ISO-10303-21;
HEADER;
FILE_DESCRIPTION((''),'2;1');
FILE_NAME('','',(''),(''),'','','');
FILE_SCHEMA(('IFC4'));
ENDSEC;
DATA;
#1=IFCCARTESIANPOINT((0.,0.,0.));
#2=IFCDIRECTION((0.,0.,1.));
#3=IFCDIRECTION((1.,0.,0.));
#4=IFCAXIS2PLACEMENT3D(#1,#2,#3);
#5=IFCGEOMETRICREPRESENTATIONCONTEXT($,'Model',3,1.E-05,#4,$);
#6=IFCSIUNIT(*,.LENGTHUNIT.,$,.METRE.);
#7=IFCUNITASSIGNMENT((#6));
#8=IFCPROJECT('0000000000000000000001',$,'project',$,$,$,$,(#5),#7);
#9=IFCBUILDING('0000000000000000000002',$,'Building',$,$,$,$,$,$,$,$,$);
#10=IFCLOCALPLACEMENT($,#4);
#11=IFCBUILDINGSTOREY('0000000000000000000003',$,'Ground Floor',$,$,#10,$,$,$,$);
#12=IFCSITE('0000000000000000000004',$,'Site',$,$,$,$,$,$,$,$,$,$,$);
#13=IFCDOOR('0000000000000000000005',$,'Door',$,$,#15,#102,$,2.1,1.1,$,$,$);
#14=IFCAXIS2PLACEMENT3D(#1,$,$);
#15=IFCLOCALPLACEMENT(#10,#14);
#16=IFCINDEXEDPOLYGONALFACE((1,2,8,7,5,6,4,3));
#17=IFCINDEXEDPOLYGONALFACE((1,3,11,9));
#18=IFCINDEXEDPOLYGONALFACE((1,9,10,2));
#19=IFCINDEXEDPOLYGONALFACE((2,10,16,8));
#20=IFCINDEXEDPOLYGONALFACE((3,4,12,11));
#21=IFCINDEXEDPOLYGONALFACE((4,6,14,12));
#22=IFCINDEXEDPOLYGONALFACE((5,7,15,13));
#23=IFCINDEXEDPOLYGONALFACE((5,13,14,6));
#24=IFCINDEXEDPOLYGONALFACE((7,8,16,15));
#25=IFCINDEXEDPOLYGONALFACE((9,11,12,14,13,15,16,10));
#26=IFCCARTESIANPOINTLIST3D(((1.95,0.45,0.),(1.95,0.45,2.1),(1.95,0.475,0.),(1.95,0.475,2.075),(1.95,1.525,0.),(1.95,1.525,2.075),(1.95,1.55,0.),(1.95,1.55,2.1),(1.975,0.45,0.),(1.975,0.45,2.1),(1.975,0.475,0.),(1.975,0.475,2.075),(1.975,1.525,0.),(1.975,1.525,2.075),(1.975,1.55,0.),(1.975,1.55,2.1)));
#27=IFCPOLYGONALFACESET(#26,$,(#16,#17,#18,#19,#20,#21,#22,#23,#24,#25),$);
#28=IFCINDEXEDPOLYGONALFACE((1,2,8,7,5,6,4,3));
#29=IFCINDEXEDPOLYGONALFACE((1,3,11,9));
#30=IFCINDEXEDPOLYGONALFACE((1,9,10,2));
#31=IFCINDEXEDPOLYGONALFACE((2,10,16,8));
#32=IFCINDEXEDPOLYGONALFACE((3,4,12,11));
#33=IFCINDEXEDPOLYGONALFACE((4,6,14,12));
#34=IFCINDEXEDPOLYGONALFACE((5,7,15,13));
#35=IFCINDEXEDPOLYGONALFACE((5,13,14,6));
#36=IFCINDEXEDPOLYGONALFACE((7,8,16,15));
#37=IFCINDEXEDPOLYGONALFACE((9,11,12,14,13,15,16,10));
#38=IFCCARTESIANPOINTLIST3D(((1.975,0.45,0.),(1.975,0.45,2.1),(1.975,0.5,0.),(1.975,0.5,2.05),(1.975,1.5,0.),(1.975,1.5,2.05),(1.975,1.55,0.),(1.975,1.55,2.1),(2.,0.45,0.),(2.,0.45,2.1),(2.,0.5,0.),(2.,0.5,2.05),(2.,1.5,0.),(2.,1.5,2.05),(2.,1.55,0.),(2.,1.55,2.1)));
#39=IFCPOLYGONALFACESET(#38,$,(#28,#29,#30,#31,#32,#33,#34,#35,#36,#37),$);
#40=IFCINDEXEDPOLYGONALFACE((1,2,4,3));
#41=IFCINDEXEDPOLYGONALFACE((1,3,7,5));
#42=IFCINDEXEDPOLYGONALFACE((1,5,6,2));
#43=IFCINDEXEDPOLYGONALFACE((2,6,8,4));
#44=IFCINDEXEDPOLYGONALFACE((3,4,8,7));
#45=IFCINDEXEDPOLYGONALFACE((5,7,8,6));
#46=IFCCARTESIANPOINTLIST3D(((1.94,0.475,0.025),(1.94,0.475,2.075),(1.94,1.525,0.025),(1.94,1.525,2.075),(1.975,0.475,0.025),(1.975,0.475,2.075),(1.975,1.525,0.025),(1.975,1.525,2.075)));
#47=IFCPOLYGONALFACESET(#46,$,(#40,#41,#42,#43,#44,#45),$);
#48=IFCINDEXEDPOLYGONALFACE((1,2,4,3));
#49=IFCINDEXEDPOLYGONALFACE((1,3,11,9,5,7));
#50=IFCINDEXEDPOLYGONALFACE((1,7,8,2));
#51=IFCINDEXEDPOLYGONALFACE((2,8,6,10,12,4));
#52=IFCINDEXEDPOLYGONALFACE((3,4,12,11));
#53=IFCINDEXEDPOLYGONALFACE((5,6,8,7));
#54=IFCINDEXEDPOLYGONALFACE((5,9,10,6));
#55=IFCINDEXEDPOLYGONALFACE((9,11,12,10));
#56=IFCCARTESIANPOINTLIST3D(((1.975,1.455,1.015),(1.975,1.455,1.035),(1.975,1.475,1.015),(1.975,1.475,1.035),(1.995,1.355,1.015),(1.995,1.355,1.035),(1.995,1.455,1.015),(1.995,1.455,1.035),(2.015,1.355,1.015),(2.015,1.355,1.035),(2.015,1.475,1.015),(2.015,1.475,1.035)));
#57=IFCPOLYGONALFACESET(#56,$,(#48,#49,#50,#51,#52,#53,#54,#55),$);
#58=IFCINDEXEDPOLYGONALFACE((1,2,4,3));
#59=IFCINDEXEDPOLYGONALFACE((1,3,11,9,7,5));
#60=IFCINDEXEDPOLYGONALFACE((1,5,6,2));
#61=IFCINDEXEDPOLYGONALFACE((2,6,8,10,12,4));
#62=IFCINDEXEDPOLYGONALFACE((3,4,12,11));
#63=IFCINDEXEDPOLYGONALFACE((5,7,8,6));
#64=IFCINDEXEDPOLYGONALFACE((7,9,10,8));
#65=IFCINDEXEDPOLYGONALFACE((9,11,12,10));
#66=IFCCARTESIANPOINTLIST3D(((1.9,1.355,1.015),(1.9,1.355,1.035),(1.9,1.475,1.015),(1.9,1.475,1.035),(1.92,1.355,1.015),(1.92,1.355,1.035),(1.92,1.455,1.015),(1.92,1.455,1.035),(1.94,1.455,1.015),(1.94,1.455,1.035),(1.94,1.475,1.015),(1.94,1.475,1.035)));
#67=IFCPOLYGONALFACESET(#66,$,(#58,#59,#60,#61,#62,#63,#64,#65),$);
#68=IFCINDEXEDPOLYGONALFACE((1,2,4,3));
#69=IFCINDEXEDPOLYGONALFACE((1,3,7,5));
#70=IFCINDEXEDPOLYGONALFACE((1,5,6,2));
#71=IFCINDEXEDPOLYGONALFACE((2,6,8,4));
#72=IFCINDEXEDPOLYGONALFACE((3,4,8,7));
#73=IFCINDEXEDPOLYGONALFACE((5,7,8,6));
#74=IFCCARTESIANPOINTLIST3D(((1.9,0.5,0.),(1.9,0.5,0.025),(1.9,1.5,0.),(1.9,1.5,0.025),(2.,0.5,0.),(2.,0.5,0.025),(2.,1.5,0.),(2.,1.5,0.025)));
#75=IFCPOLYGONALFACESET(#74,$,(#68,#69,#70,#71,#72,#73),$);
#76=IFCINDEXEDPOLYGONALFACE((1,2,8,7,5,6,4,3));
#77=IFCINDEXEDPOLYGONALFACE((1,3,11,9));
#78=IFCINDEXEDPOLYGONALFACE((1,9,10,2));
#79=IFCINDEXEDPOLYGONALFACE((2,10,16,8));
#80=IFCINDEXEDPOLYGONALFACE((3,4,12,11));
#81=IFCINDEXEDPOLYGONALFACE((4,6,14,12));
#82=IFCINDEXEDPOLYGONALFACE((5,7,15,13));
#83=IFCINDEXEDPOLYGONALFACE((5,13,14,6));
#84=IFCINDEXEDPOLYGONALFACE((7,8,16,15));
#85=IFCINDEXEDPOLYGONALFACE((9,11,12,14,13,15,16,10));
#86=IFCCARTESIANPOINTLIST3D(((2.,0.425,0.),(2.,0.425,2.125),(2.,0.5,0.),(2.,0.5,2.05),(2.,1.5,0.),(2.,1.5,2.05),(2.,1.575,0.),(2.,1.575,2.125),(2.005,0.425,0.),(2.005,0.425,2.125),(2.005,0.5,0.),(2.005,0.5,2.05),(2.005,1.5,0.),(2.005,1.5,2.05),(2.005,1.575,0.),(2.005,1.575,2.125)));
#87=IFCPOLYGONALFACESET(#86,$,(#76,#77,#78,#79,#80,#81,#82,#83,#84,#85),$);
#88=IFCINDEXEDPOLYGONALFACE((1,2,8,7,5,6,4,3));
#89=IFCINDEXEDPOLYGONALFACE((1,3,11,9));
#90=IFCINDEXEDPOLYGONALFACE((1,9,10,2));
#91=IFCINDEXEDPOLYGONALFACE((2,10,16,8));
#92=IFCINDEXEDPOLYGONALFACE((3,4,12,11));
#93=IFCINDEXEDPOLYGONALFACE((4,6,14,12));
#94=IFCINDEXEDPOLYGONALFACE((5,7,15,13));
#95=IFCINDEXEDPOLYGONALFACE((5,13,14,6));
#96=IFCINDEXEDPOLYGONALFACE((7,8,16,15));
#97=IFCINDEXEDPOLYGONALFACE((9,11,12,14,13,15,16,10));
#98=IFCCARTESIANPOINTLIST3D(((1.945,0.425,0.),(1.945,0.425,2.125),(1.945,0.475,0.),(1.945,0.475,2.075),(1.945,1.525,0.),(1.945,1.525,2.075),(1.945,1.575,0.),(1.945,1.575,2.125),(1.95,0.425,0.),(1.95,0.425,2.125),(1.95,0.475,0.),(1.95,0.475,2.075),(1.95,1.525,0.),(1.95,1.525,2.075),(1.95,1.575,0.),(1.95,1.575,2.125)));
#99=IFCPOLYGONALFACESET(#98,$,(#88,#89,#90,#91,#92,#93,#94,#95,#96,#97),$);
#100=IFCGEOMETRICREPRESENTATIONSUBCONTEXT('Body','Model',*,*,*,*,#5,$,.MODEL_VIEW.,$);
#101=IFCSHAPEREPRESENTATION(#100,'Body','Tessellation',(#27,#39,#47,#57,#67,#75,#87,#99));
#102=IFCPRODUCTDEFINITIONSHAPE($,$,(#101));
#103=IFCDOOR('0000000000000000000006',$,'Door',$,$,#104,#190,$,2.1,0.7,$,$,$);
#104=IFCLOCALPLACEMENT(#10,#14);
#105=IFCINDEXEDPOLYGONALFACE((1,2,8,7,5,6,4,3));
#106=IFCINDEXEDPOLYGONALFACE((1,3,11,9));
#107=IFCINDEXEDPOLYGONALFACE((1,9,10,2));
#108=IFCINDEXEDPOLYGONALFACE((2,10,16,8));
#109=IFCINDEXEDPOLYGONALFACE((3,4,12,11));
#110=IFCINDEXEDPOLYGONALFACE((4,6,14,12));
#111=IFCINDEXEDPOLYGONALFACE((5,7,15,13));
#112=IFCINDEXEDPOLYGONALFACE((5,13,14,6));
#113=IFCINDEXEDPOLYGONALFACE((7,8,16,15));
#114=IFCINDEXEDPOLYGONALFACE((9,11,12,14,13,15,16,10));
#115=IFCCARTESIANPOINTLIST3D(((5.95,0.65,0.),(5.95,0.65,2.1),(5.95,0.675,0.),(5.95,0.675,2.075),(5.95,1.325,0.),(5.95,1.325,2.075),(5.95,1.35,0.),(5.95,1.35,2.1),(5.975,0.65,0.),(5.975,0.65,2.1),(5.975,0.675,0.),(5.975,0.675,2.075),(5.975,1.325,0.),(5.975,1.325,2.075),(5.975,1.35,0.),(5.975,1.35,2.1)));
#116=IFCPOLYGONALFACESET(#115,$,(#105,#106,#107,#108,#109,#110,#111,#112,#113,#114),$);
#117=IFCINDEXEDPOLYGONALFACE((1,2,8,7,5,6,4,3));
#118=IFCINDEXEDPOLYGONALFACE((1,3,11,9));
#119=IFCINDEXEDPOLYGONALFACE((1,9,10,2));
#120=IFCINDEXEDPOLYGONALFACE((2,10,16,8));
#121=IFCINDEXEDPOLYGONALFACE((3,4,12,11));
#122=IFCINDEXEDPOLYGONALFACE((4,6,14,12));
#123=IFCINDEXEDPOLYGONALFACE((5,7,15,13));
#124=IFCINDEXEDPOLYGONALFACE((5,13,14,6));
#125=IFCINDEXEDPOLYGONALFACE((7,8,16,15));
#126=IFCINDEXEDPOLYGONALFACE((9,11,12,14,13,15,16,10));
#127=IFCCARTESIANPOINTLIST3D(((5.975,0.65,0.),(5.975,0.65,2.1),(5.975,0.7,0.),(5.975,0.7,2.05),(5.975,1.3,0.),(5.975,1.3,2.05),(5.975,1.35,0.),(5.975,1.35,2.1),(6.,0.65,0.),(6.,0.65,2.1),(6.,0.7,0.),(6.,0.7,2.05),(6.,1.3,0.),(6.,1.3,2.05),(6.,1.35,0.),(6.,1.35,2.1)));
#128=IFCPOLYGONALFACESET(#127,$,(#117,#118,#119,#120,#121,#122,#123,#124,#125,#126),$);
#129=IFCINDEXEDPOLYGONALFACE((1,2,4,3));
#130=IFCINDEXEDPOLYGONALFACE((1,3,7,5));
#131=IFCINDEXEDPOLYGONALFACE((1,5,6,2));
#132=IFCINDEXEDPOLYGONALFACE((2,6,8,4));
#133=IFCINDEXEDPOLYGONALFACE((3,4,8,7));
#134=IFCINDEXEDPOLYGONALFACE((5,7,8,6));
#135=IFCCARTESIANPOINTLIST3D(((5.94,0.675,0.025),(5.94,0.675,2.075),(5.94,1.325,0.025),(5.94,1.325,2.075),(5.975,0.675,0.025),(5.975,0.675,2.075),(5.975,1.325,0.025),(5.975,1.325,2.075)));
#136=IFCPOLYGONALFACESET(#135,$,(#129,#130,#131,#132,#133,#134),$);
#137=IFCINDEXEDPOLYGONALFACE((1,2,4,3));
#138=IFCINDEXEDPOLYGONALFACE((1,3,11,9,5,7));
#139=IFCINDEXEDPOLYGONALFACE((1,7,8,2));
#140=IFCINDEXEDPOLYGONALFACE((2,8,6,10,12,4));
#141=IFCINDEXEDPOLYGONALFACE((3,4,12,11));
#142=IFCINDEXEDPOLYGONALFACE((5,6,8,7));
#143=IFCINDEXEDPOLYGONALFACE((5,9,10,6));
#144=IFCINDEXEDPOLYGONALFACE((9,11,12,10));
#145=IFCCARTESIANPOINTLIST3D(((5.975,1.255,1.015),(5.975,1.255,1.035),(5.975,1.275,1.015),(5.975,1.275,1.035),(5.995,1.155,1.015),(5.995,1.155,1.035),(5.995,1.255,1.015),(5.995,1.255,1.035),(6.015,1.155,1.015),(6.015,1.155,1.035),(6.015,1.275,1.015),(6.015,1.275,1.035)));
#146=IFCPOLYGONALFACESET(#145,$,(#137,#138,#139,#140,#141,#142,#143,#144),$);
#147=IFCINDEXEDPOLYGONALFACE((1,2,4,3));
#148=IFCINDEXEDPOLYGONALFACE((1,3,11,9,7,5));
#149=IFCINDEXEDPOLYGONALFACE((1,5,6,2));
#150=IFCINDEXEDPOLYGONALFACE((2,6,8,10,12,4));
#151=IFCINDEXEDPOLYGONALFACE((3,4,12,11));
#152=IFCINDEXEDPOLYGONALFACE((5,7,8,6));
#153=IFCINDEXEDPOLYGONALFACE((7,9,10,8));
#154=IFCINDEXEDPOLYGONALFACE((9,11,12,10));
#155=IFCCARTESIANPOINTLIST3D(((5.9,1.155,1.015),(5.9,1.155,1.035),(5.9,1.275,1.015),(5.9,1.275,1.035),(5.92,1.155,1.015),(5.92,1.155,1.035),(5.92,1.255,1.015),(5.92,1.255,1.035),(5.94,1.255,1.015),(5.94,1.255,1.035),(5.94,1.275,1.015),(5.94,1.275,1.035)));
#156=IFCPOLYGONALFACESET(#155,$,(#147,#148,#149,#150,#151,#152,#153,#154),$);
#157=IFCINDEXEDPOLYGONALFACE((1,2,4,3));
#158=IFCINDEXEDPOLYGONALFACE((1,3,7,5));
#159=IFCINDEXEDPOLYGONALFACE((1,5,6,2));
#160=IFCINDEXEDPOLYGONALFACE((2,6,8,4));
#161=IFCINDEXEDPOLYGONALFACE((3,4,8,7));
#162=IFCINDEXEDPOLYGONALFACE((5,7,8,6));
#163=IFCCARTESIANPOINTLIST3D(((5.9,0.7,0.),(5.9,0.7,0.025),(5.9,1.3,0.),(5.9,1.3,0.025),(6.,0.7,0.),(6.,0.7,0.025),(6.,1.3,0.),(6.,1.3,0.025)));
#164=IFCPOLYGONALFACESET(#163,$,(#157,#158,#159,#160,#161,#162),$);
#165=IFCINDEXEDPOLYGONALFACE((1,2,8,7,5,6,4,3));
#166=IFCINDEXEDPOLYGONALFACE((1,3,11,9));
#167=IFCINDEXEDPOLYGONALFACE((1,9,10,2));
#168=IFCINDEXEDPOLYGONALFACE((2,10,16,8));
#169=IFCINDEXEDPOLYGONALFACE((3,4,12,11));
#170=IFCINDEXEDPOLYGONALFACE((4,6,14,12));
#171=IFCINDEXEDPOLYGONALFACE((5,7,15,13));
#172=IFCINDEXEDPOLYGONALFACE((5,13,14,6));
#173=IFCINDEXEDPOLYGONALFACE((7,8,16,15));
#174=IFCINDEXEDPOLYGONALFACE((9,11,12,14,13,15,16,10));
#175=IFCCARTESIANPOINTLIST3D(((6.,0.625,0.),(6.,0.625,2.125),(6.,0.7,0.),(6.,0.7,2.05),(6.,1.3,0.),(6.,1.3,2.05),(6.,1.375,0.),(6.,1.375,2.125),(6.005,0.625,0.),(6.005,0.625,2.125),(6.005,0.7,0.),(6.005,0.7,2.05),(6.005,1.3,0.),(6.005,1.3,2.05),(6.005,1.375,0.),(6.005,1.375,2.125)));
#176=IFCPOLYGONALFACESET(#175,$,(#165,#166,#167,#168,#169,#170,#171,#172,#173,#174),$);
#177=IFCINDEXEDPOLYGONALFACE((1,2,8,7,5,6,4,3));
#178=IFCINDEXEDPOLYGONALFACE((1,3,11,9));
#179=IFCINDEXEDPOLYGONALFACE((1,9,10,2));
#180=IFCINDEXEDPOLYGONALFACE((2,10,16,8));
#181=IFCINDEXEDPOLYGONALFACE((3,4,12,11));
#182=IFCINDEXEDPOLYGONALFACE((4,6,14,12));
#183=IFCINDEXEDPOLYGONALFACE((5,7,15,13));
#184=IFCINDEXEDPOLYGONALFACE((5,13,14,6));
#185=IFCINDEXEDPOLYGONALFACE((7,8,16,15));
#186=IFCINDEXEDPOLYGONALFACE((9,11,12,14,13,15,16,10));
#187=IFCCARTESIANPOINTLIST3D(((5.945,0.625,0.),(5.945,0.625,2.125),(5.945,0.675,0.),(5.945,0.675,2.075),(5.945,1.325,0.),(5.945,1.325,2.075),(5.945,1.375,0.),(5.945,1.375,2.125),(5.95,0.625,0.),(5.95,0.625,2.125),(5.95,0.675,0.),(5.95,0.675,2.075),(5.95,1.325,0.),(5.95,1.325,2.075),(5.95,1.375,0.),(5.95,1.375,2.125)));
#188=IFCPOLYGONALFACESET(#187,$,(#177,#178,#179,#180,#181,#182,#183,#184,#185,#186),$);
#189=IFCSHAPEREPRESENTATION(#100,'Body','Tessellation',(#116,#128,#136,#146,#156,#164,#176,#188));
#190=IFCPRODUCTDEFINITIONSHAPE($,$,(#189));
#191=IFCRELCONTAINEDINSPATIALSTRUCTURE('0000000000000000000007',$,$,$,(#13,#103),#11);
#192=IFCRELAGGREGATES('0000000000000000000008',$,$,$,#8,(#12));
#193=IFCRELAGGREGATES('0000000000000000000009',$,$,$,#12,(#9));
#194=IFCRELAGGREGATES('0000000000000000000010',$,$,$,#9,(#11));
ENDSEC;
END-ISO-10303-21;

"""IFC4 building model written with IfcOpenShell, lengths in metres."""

from ifc_helpers import new_model, si_unit, frame, origin_with_axes, place, context, subcontext, project, spatial, line, indexed_curve, outline, extrude, element, save


model = new_model("IFC4")

# Units and contexts
model_context = context("Model", 3, precision=1e-05, world=origin_with_axes())
body_context = subcontext(model_context, "Body", "Model", "MODEL_VIEW")
ifc_project = project(units=[si_unit("LENGTHUNIT", "METRE")], contexts=[model_context])

# Site, building, storey
site = spatial("IfcSite", under=ifc_project, Name="Site")
building = spatial("IfcBuilding", under=site, Name="Building")
storey_placement = place(None, origin_with_axes())
storey = spatial("IfcBuildingStorey", under=building, at=storey_placement, Name="Ground Floor")

# Doors
door_1_placement = place(storey_placement, frame((2.0, 0.45, 0.0), z_axis=(0.0, 0.0, 1.0), x_axis=(0.0, 1.0, 0.0)))
element("IfcDoor", 1, at=door_1_placement, inside=storey, Name="Door", OverallHeight=2.1, OverallWidth=1.1, context=body_context, shape_type="SweptSolid", body=[
    extrude(outline(indexed_curve([(0.0, 0.0), (0.0, 2.1), (1.1, 2.1), (1.1, 0.0), (1.075, 0.0), (1.075, 2.075), (0.025, 2.075), (0.025, 0.0)], segments=[line(1, 2, 3, 4, 5, 6, 7, 8, 1)])), frame((0.0, 0.025, 0.0), z_axis=(0.0, -1.0, 0.0), x_axis=(1.0, 0.0, 0.0)), (0.0, 0.0, -1.0), 0.025),
    extrude(outline(indexed_curve([(0.0, 0.0), (0.0, 2.1), (1.1, 2.1), (1.1, 0.0), (1.05, 0.0), (1.05, 2.05), (0.05, 2.05), (0.05, 0.0)], segments=[line(1, 2, 3, 4, 5, 6, 7, 8, 1)])), frame((0.0, 0.0, 0.0), z_axis=(0.0, -1.0, 0.0), x_axis=(1.0, 0.0, 0.0)), (0.0, 0.0, -1.0), 0.025),
    extrude(outline(indexed_curve([(0.0, 0.0), (1.05, 0.0), (1.05, 0.035), (0.0, 0.035)], segments=[line(1, 2, 3, 4, 1)])), frame((0.025, 0.025, 0.025), z_axis=(0.0, 0.0, 1.0), x_axis=(1.0, 0.0, 0.0)), (0.0, 0.0, 1.0), 2.05),
    extrude(outline(indexed_curve([(0.0, 0.0), (0.0, -0.04), (-0.12, -0.04), (-0.12, -0.02), (-0.02, -0.02), (-0.02, 0.0)], segments=[line(1, 2, 3, 4, 5, 6, 1)])), frame((1.025, 0.025, 1.015), z_axis=(0.0, 0.0, 1.0), x_axis=(1.0, 0.0, 0.0)), (0.0, 0.0, 1.0), 0.02),
    extrude(outline(indexed_curve([(0.0, 0.0), (0.0, 0.04), (-0.12, 0.04), (-0.12, 0.02), (-0.02, 0.02), (-0.02, 0.0)], segments=[line(1, 2, 3, 4, 5, 6, 1)])), frame((1.025, 0.06, 1.015), z_axis=(0.0, 0.0, 1.0), x_axis=(1.0, 0.0, 0.0)), (0.0, 0.0, 1.0), 0.02),
    extrude(outline(indexed_curve([(0.0, 0.0), (1.0, 0.0), (1.0, 0.1), (0.0, 0.1)], segments=[line(1, 2, 3, 4, 1)])), frame((0.05, 0.0, 0.0), z_axis=(0.0, 0.0, 1.0), x_axis=(1.0, 0.0, 0.0)), (0.0, 0.0, 1.0), 0.025),
    extrude(outline(indexed_curve([(0.0, 0.0), (0.0, 2.125), (1.15, 2.125), (1.15, 0.0), (1.075, 0.0), (1.075, 2.05), (0.075, 2.05), (0.075, 0.0)], segments=[line(1, 2, 3, 4, 5, 6, 7, 8, 1)])), frame((-0.025, -0.005, 0.0), z_axis=(0.0, -1.0, 0.0), x_axis=(1.0, 0.0, 0.0)), (0.0, 0.0, -1.0), 0.005),
    extrude(outline(indexed_curve([(0.0, 0.0), (0.0, 2.125), (1.15, 2.125), (1.15, 0.0), (1.1, 0.0), (1.1, 2.075), (0.05, 2.075), (0.05, 0.0)], segments=[line(1, 2, 3, 4, 5, 6, 7, 8, 1)])), frame((-0.025, 0.05, 0.0), z_axis=(0.0, -1.0, 0.0), x_axis=(1.0, 0.0, 0.0)), (0.0, 0.0, -1.0), 0.005),
])
door_2_placement = place(storey_placement, frame((6.0, 0.65, 0.0), z_axis=(0.0, 0.0, 1.0), x_axis=(0.0, 1.0, 0.0)))
element("IfcDoor", 2, at=door_2_placement, inside=storey, Name="Door", OverallHeight=2.1, OverallWidth=0.7, context=body_context, shape_type="SweptSolid", body=[
    extrude(outline(indexed_curve([(0.0, 0.0), (0.0, 2.1), (0.7, 2.1), (0.7, 0.0), (0.675, 0.0), (0.675, 2.075), (0.025, 2.075), (0.025, 0.0)], segments=[line(1, 2, 3, 4, 5, 6, 7, 8, 1)])), frame((0.0, 0.025, 0.0), z_axis=(0.0, -1.0, 0.0), x_axis=(1.0, 0.0, 0.0)), (0.0, 0.0, -1.0), 0.025),
    extrude(outline(indexed_curve([(0.0, 0.0), (0.0, 2.1), (0.7, 2.1), (0.7, 0.0), (0.65, 0.0), (0.65, 2.05), (0.05, 2.05), (0.05, 0.0)], segments=[line(1, 2, 3, 4, 5, 6, 7, 8, 1)])), frame((0.0, 0.0, 0.0), z_axis=(0.0, -1.0, 0.0), x_axis=(1.0, 0.0, 0.0)), (0.0, 0.0, -1.0), 0.025),
    extrude(outline(indexed_curve([(0.0, 0.0), (0.65, 0.0), (0.65, 0.035), (0.0, 0.035)], segments=[line(1, 2, 3, 4, 1)])), frame((0.025, 0.025, 0.025), z_axis=(0.0, 0.0, 1.0), x_axis=(1.0, 0.0, 0.0)), (0.0, 0.0, 1.0), 2.05),
    extrude(outline(indexed_curve([(0.0, 0.0), (0.0, -0.04), (-0.12, -0.04), (-0.12, -0.02), (-0.02, -0.02), (-0.02, 0.0)], segments=[line(1, 2, 3, 4, 5, 6, 1)])), frame((0.625, 0.025, 1.015), z_axis=(0.0, 0.0, 1.0), x_axis=(1.0, 0.0, 0.0)), (0.0, 0.0, 1.0), 0.02),
    extrude(outline(indexed_curve([(0.0, 0.0), (0.0, 0.04), (-0.12, 0.04), (-0.12, 0.02), (-0.02, 0.02), (-0.02, 0.0)], segments=[line(1, 2, 3, 4, 5, 6, 1)])), frame((0.625, 0.06, 1.015), z_axis=(0.0, 0.0, 1.0), x_axis=(1.0, 0.0, 0.0)), (0.0, 0.0, 1.0), 0.02),
    extrude(outline(indexed_curve([(0.0, 0.0), (0.6, 0.0), (0.6, 0.1), (0.0, 0.1)], segments=[line(1, 2, 3, 4, 1)])), frame((0.05, 0.0, 0.0), z_axis=(0.0, 0.0, 1.0), x_axis=(1.0, 0.0, 0.0)), (0.0, 0.0, 1.0), 0.025),
    extrude(outline(indexed_curve([(0.0, 0.0), (0.0, 2.125), (0.75, 2.125), (0.75, 0.0), (0.675, 0.0), (0.675, 2.05), (0.075, 2.05), (0.075, 0.0)], segments=[line(1, 2, 3, 4, 5, 6, 7, 8, 1)])), frame((-0.025, -0.005, 0.0), z_axis=(0.0, -1.0, 0.0), x_axis=(1.0, 0.0, 0.0)), (0.0, 0.0, -1.0), 0.005),
    extrude(outline(indexed_curve([(0.0, 0.0), (0.0, 2.125), (0.75, 2.125), (0.75, 0.0), (0.7, 0.0), (0.7, 2.075), (0.05, 2.075), (0.05, 0.0)], segments=[line(1, 2, 3, 4, 5, 6, 7, 8, 1)])), frame((-0.025, 0.05, 0.0), z_axis=(0.0, -1.0, 0.0), x_axis=(1.0, 0.0, 0.0)), (0.0, 0.0, -1.0), 0.005),
])

save(model, "model.ifc")
